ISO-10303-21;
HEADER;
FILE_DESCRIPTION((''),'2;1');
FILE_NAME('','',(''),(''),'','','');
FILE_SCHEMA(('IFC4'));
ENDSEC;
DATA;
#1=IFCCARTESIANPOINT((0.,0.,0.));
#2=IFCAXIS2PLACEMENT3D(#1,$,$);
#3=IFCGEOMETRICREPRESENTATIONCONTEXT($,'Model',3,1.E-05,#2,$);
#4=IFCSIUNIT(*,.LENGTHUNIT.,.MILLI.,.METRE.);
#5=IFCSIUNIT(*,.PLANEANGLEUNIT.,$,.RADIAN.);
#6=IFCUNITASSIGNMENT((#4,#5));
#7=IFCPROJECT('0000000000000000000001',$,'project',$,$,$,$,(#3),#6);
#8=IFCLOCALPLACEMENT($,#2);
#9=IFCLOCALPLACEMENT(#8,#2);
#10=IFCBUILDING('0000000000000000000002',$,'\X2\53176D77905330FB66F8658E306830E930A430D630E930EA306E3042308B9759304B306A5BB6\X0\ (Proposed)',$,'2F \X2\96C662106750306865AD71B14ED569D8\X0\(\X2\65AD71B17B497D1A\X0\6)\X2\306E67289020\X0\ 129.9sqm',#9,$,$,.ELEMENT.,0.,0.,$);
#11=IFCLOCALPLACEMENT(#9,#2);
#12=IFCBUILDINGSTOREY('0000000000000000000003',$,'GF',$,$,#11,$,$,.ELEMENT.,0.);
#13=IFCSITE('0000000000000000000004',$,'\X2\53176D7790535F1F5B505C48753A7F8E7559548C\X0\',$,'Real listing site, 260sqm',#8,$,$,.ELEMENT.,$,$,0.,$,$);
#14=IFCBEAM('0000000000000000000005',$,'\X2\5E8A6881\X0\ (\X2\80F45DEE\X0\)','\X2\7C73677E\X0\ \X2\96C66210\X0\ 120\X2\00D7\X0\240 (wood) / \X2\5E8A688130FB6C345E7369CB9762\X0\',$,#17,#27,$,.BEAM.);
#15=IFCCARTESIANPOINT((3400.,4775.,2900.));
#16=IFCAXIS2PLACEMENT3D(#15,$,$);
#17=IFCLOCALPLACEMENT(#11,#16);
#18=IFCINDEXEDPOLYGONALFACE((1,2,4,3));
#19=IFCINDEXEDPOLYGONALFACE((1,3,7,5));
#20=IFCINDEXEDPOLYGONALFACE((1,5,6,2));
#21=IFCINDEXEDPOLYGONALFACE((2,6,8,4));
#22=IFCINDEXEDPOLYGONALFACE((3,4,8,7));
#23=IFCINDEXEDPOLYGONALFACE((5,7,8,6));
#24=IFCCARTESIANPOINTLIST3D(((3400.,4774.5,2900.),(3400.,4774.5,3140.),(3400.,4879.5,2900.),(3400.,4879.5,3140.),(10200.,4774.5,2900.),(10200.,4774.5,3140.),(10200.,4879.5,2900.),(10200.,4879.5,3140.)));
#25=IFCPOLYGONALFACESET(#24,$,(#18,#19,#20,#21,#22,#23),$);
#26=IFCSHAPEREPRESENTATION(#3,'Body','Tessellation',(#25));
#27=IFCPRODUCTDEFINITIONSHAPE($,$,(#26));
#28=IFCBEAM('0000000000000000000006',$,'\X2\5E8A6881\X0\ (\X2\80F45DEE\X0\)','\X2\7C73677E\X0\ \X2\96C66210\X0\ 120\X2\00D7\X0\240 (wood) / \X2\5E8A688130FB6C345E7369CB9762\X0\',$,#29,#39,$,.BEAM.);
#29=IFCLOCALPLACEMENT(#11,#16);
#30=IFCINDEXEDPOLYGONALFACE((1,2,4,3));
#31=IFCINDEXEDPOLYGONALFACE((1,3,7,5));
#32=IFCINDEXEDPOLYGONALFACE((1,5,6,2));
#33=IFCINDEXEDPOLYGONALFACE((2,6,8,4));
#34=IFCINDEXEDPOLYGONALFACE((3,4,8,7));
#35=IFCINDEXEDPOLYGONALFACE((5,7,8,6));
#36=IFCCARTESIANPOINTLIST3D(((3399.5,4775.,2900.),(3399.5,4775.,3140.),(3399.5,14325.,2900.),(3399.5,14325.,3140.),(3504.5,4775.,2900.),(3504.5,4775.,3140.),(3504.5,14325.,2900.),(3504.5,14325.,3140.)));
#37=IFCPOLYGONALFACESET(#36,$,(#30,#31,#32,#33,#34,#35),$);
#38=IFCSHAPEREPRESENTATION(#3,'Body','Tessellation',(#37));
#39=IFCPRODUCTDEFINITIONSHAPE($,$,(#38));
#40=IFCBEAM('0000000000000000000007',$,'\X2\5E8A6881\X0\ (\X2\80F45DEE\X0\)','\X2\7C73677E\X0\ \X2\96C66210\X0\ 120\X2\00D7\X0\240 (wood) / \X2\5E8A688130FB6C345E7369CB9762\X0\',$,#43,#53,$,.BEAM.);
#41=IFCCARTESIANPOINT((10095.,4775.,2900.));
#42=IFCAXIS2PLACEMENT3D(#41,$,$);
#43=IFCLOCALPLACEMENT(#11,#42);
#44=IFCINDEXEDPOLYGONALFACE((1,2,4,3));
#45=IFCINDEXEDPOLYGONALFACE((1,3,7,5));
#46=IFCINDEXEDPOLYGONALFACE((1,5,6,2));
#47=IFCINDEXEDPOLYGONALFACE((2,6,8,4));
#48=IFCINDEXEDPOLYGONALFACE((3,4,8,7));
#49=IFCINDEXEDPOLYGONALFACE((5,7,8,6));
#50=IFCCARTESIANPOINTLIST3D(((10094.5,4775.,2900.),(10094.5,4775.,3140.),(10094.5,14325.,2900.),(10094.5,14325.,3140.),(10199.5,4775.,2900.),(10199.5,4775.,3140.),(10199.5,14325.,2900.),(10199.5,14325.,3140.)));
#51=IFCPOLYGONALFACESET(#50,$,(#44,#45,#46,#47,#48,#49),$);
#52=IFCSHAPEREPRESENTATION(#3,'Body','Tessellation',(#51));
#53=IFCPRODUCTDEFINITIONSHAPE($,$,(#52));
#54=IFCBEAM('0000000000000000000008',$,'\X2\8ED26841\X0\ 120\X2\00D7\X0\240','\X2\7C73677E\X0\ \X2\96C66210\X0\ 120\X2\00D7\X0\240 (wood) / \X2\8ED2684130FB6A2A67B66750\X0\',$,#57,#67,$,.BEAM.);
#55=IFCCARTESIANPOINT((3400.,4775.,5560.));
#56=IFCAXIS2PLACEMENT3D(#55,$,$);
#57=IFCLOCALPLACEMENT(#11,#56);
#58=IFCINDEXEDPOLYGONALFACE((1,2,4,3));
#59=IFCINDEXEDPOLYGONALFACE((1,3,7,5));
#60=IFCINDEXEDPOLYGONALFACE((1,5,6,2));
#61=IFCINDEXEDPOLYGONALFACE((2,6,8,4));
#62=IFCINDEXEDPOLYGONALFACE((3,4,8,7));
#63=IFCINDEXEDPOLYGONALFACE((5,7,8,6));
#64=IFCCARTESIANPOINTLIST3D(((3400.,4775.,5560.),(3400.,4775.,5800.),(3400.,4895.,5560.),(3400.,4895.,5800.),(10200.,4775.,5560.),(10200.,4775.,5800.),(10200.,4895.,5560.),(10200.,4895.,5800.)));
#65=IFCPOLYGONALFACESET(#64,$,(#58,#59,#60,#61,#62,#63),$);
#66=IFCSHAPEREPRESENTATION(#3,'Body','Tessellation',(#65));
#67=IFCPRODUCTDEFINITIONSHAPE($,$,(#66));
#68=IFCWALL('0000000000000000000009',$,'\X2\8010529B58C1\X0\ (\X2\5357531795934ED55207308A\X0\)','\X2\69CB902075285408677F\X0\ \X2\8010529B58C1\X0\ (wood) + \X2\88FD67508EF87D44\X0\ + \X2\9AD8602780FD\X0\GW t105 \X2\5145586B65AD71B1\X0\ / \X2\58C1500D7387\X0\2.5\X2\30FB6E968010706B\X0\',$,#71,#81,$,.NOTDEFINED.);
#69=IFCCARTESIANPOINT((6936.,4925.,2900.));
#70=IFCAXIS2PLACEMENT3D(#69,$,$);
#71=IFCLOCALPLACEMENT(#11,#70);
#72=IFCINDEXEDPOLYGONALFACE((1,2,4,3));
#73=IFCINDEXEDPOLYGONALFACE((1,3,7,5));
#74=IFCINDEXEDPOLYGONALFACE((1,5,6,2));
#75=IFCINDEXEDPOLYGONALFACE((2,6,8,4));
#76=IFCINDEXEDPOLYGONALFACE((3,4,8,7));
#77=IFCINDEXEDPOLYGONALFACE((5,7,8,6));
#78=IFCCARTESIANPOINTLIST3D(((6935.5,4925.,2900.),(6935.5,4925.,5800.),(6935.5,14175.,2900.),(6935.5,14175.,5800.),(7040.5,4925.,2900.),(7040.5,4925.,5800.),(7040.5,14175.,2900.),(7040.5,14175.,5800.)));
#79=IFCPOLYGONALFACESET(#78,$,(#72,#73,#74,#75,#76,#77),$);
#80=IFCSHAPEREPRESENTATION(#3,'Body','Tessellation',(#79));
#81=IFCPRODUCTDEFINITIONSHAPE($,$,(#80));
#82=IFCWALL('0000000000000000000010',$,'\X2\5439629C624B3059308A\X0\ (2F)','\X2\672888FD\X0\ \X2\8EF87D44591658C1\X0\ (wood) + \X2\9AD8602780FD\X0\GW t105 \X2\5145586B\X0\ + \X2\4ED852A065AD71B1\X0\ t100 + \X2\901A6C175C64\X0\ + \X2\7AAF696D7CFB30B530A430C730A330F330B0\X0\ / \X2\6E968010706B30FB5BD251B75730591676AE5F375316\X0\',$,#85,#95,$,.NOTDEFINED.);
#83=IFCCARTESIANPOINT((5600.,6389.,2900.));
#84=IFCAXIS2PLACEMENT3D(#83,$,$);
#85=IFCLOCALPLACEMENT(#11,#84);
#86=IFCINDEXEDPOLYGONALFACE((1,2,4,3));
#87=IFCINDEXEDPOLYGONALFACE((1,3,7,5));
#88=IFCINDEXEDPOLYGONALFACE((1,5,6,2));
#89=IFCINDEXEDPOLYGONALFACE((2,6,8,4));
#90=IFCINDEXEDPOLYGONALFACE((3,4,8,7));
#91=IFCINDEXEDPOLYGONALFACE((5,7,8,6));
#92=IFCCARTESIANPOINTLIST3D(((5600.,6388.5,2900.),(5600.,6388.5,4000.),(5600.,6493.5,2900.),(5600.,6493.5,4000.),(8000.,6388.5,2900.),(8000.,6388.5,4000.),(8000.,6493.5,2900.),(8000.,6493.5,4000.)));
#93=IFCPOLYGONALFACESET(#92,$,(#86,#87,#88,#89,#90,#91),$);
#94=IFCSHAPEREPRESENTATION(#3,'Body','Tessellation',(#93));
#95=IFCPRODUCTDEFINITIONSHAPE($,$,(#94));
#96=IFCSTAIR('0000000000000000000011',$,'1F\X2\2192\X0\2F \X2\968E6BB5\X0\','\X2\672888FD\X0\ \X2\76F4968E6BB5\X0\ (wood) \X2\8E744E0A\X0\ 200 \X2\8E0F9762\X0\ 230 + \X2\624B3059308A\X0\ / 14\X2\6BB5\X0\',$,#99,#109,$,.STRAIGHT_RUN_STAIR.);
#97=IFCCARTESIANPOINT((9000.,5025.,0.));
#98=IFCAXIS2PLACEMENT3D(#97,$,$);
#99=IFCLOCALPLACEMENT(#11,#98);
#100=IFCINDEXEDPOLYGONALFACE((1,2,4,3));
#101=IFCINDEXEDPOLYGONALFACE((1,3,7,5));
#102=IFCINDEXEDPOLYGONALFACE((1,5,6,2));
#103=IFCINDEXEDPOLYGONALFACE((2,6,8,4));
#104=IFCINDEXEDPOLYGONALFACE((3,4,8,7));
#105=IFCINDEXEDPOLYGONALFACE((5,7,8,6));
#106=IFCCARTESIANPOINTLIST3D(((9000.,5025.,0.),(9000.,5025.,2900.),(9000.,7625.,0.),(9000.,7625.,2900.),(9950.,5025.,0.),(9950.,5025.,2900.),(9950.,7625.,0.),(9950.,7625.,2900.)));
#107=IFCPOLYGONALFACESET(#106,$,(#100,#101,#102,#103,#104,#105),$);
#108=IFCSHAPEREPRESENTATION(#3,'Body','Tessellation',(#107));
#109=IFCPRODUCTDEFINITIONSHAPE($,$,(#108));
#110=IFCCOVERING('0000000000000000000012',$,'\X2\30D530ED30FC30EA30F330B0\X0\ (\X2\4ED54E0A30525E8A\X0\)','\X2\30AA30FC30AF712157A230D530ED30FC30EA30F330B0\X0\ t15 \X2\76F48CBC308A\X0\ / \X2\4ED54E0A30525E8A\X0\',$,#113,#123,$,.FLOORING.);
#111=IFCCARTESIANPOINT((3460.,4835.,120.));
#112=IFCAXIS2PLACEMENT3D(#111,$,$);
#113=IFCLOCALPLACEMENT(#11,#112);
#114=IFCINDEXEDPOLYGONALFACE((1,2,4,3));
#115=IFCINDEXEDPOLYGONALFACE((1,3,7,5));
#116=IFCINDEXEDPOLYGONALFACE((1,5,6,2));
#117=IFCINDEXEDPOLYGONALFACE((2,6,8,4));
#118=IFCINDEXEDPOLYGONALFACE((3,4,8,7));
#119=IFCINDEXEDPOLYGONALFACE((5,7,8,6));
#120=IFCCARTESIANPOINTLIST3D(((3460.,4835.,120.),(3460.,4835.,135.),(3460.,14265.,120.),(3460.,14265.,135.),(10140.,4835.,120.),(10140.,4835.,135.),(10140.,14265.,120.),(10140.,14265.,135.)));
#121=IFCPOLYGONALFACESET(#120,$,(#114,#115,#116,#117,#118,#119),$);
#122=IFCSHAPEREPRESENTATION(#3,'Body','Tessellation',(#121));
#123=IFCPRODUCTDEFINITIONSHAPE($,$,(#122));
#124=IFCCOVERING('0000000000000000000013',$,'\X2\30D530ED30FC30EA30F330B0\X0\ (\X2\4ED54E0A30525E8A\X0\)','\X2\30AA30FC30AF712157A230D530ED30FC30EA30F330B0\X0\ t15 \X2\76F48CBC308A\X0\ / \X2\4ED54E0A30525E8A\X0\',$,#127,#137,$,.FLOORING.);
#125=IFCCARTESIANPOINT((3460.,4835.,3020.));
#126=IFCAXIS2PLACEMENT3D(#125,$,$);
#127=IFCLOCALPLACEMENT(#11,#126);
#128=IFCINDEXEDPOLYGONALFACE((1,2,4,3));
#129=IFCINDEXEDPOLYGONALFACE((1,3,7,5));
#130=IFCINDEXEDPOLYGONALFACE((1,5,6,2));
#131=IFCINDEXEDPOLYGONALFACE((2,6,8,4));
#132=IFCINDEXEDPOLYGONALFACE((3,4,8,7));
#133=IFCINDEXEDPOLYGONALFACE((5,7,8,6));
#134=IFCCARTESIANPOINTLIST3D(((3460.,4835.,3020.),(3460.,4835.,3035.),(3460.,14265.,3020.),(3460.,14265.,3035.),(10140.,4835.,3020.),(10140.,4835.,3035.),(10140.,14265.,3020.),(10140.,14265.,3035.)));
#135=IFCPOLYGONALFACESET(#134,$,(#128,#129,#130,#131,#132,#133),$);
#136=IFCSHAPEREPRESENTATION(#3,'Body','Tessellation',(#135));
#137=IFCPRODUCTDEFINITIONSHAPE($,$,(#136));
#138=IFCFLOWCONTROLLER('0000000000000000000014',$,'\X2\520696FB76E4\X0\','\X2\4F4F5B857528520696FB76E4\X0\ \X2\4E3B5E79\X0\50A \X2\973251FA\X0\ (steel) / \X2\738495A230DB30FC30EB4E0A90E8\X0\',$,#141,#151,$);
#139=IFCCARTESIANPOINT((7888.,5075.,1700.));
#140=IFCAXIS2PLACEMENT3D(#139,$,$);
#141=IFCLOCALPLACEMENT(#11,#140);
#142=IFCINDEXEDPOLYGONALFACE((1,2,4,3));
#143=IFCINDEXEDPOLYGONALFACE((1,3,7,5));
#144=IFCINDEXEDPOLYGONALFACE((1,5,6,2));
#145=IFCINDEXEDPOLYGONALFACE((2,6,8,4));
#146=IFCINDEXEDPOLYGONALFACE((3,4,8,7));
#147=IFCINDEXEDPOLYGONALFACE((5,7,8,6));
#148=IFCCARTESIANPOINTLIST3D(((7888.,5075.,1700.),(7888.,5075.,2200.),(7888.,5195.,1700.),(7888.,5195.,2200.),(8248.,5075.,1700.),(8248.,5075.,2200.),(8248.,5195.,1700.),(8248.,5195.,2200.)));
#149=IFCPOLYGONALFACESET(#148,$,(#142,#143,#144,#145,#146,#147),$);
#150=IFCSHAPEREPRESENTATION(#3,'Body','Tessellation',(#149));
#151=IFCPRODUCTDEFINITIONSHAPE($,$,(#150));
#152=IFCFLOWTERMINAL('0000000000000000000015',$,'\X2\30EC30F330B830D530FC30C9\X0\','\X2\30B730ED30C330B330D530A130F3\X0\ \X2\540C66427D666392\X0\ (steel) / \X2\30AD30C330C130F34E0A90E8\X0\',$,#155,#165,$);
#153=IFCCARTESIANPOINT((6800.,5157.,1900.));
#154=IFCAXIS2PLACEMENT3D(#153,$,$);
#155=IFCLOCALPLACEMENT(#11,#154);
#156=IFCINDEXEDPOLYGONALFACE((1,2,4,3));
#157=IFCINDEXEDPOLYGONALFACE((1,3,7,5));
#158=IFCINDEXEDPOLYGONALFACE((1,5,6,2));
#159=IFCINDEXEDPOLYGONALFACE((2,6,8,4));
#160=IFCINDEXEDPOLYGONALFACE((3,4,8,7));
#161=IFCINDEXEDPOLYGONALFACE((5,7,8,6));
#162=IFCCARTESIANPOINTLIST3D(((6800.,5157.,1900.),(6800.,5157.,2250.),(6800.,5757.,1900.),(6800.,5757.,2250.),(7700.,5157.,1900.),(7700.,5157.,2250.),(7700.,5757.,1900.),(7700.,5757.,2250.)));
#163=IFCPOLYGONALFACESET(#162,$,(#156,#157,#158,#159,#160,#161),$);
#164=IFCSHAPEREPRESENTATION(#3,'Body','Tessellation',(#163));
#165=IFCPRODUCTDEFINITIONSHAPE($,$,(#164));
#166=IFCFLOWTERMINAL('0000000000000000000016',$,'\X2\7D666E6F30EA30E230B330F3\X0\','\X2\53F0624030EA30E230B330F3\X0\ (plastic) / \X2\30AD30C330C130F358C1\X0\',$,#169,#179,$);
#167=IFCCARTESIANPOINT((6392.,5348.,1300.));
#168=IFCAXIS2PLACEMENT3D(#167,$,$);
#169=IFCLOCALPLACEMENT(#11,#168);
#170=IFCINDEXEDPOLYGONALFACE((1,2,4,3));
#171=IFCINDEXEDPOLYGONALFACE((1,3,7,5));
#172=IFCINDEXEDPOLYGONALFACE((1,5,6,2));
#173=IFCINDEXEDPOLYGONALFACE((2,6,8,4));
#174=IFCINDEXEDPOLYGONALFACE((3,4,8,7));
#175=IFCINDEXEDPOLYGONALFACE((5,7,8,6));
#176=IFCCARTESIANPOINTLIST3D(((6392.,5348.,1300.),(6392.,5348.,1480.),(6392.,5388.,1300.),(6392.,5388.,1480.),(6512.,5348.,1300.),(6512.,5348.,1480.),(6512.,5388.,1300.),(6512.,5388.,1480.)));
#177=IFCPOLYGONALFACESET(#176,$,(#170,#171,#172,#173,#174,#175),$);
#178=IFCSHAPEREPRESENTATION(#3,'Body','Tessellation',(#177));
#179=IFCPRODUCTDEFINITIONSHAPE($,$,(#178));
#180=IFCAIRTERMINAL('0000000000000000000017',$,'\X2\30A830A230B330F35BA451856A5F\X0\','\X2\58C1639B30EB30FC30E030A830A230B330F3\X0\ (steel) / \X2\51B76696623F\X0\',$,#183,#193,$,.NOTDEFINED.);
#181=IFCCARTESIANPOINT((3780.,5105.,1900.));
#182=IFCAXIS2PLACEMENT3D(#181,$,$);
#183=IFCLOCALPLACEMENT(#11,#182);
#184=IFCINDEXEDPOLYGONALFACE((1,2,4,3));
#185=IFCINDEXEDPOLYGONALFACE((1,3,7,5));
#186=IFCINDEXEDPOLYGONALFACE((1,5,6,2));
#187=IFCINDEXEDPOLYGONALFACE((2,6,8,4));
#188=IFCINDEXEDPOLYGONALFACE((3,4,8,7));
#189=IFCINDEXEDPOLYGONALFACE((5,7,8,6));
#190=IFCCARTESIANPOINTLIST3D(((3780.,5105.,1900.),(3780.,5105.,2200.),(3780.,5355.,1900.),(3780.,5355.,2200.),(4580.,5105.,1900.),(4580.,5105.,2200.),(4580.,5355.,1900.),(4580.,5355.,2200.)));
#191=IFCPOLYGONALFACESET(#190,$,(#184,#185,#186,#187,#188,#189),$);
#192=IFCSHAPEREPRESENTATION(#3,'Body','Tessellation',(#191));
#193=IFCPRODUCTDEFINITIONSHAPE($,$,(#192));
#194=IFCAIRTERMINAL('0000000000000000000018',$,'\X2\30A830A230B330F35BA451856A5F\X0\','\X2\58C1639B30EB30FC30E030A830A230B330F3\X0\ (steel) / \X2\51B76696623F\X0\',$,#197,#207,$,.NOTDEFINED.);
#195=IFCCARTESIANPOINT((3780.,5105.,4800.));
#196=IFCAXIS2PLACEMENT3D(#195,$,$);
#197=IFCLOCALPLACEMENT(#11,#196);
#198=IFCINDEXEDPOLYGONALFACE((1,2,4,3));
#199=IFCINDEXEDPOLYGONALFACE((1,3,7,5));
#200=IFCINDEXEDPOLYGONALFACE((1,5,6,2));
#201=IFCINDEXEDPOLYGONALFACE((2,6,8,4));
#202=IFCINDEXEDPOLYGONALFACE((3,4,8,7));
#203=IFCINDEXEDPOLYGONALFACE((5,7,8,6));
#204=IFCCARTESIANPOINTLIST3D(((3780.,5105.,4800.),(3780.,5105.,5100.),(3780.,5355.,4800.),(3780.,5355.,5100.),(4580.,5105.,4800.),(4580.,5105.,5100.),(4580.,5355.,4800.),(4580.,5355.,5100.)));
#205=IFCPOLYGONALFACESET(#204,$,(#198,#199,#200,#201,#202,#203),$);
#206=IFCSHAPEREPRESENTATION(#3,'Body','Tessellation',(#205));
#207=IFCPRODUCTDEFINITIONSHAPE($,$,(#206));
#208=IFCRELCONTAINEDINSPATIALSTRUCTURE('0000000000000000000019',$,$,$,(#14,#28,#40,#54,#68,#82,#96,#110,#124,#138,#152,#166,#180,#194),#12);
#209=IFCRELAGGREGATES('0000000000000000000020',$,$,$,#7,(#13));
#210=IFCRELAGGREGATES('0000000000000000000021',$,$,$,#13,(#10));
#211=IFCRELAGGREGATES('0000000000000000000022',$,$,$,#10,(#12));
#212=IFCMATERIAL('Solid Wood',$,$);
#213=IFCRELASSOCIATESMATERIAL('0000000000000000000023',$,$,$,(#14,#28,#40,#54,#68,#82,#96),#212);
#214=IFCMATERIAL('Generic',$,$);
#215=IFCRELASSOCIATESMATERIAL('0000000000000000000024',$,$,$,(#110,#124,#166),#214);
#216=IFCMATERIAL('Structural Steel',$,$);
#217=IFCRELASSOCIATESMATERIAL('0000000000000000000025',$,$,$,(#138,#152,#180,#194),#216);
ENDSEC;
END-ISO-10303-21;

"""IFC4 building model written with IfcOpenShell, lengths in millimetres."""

from ifc_helpers import new_model, si_unit, frame, frame_2d, origin, place, context, project, spatial, rectangle, extrude, material, element, save


model = new_model("IFC4")

# Units and contexts
model_context = context("Model", 3, precision=1e-05, world=origin())
ifc_project = project(units=[si_unit("LENGTHUNIT", "METRE", prefix="MILLI"), si_unit("PLANEANGLEUNIT", "RADIAN")], contexts=[model_context])

# Site, building, storey
site_placement = place(None, origin())
site = spatial("IfcSite", under=ifc_project, at=site_placement, Name="北海道弟子屈町美留和", ObjectType="Real listing site, 260sqm", CompositionType="ELEMENT", RefElevation=0.0)
building_placement = place(site_placement, origin())
building = spatial("IfcBuilding", under=site, at=building_placement, Name="北海道・書斎とライブラリのある静かな家 (Proposed)", ObjectType="2F 集成材と断熱仕様(断熱等級6)の木造 129.9sqm", CompositionType="ELEMENT", ElevationOfRefHeight=0.0, ElevationOfTerrain=0.0)
storey_placement = place(building_placement, origin())
storey = spatial("IfcBuildingStorey", under=building, at=storey_placement, Name="GF", CompositionType="ELEMENT", Elevation=0.0)

# Shared definitions
ifc_material_1 = material(Name="Solid Wood")

# Beams
beam_1_placement = place(storey_placement, frame((3400.0, 4775.0, 2900.0)))
element("IfcBeam", 1, at=beam_1_placement, inside=storey, material=ifc_material_1, Name="床梁 (胴差)", Description="米松 集成 120×240 (wood) / 床梁・水平構面", PredefinedType="BEAM", context=model_context, shape_type="SweptSolid", body=[
    extrude(rectangle(XDim=6800.0, YDim=105.0, at=frame_2d((3400.0, 52.0))), frame((3400.0, 4775.0, 2900.0)), (0.0, 0.0, 1.0), 240.0),
])
beam_2_placement = place(storey_placement, frame((3400.0, 4775.0, 2900.0)))
element("IfcBeam", 2, at=beam_2_placement, inside=storey, material=ifc_material_1, Name="床梁 (胴差)", Description="米松 集成 120×240 (wood) / 床梁・水平構面", PredefinedType="BEAM", context=model_context, shape_type="SweptSolid", body=[
    extrude(rectangle(XDim=105.0, YDim=9550.0, at=frame_2d((52.0, 4775.0))), frame((3400.0, 4775.0, 2900.0)), (0.0, 0.0, 1.0), 240.0),
])
beam_3_placement = place(storey_placement, frame((10095.0, 4775.0, 2900.0)))
element("IfcBeam", 3, at=beam_3_placement, inside=storey, material=ifc_material_1, Name="床梁 (胴差)", Description="米松 集成 120×240 (wood) / 床梁・水平構面", PredefinedType="BEAM", context=model_context, shape_type="SweptSolid", body=[
    extrude(rectangle(XDim=105.0, YDim=9550.0, at=frame_2d((52.0, 4775.0))), frame((10095.0, 4775.0, 2900.0)), (0.0, 0.0, 1.0), 240.0),
])
beam_4_placement = place(storey_placement, frame((3400.0, 4775.0, 5560.0)))
element("IfcBeam", 4, at=beam_4_placement, inside=storey, material=ifc_material_1, Name="軒桁 120×240", Description="米松 集成 120×240 (wood) / 軒桁・横架材", PredefinedType="BEAM", context=model_context, shape_type="SweptSolid", body=[
    extrude(rectangle(XDim=6800.0, YDim=120.0, at=frame_2d((3400.0, 60.0))), frame((3400.0, 4775.0, 5560.0)), (0.0, 0.0, 1.0), 240.0),
])

# Walls
wall_1_placement = place(storey_placement, frame((6936.0, 4925.0, 2900.0)))
element("IfcWall", 5, at=wall_1_placement, inside=storey, material=ifc_material_1, Name="耐力壁 (南北間仕切り)", Description="構造用合板 耐力壁 (wood) + 製材軸組 + 高性能GW t105 充填断熱 / 壁倍率2.5・準耐火", PredefinedType="NOTDEFINED", context=model_context, shape_type="SweptSolid", body=[
    extrude(rectangle(XDim=105.0, YDim=9250.0, at=frame_2d((52.0, 4625.0))), frame((6936.0, 4925.0, 2900.0)), (0.0, 0.0, 1.0), 2900.0),
])
wall_2_placement = place(storey_placement, frame((5600.0, 6389.0, 2900.0)))
element("IfcWall", 6, at=wall_2_placement, inside=storey, material=ifc_material_1, Name="吹抜手すり (2F)", Description="木製 軸組外壁 (wood) + 高性能GW t105 充填 + 付加断熱 t100 + 通気層 + 窯業系サイディング / 準耐火・寒冷地外皮強化", PredefinedType="NOTDEFINED", context=model_context, shape_type="SweptSolid", body=[
    extrude(rectangle(XDim=2400.0, YDim=105.0, at=frame_2d((1200.0, 52.0))), frame((5600.0, 6389.0, 2900.0)), (0.0, 0.0, 1.0), 1100.0),
])

# Stair
stair_placement = place(storey_placement, frame((9000.0, 5025.0, 0.0)))
element("IfcStair", 7, at=stair_placement, inside=storey, material=ifc_material_1, Name="1F→2F 階段", Description="木製 直階段 (wood) 蹴上 200 踏面 230 + 手すり / 14段", PredefinedType="STRAIGHT_RUN_STAIR", context=model_context, shape_type="SweptSolid", body=[
    extrude(rectangle(XDim=950.0, YDim=2600.0, at=frame_2d((475.0, 1300.0))), frame((9000.0, 5025.0, 0.0)), (0.0, 0.0, 1.0), 2900.0),
])

# Coverings
ifc_material_2 = material(Name="Generic")
covering_1_placement = place(storey_placement, frame((3460.0, 4835.0, 120.0)))
element("IfcCovering", 8, at=covering_1_placement, inside=storey, material=ifc_material_2, Name="フローリング (仕上げ床)", Description="オーク無垢フローリング t15 直貼り / 仕上げ床", PredefinedType="FLOORING", context=model_context, shape_type="SweptSolid", body=[
    extrude(rectangle(XDim=6680.0, YDim=9430.0, at=frame_2d((3340.0, 4715.0))), frame((3460.0, 4835.0, 120.0)), (0.0, 0.0, 1.0), 15.0),
])
covering_2_placement = place(storey_placement, frame((3460.0, 4835.0, 3020.0)))
element("IfcCovering", 9, at=covering_2_placement, inside=storey, material=ifc_material_2, Name="フローリング (仕上げ床)", Description="オーク無垢フローリング t15 直貼り / 仕上げ床", PredefinedType="FLOORING", context=model_context, shape_type="SweptSolid", body=[
    extrude(rectangle(XDim=6680.0, YDim=9430.0, at=frame_2d((3340.0, 4715.0))), frame((3460.0, 4835.0, 3020.0)), (0.0, 0.0, 1.0), 15.0),
])

# Flow controller
ifc_material_3 = material(Name="Structural Steel")
flow_controller_placement = place(storey_placement, frame((7888.0, 5075.0, 1700.0)))
element("IfcFlowController", 10, at=flow_controller_placement, inside=storey, material=ifc_material_3, Name="分電盤", Description="住宅用分電盤 主幹50A 露出 (steel) / 玄関ホール上部", context=model_context, shape_type="SweptSolid", body=[
    extrude(rectangle(XDim=360.0, YDim=120.0, at=frame_2d((180.0, 60.0))), frame((7888.0, 5075.0, 1700.0)), (0.0, 0.0, 1.0), 500.0),
])

# Flow terminals
flow_terminal_1_placement = place(storey_placement, frame((6800.0, 5157.0, 1900.0)))
element("IfcFlowTerminal", 11, at=flow_terminal_1_placement, inside=storey, material=ifc_material_3, Name="レンジフード", Description="シロッコファン 同時給排 (steel) / キッチン上部", context=model_context, shape_type="SweptSolid", body=[
    extrude(rectangle(XDim=900.0, YDim=600.0, at=frame_2d((450.0, 300.0))), frame((6800.0, 5157.0, 1900.0)), (0.0, 0.0, 1.0), 350.0),
])
flow_terminal_2_placement = place(storey_placement, frame((6392.0, 5348.0, 1300.0)))
element("IfcFlowTerminal", 12, at=flow_terminal_2_placement, inside=storey, material=ifc_material_2, Name="給湯リモコン", Description="台所リモコン (plastic) / キッチン壁", context=model_context, shape_type="SweptSolid", body=[
    extrude(rectangle(XDim=120.0, YDim=40.0, at=frame_2d((60.0, 20.0))), frame((6392.0, 5348.0, 1300.0)), (0.0, 0.0, 1.0), 180.0),
])

# Air terminals
air_terminal_1_placement = place(storey_placement, frame((3780.0, 5105.0, 1900.0)))
element("IfcAirTerminal", 13, at=air_terminal_1_placement, inside=storey, material=ifc_material_3, Name="エアコン室内機", Description="壁掛ルームエアコン (steel) / 冷暖房", PredefinedType="NOTDEFINED", context=model_context, shape_type="SweptSolid", body=[
    extrude(rectangle(XDim=800.0, YDim=250.0, at=frame_2d((400.0, 125.0))), frame((3780.0, 5105.0, 1900.0)), (0.0, 0.0, 1.0), 300.0),
])
air_terminal_2_placement = place(storey_placement, frame((3780.0, 5105.0, 4800.0)))
element("IfcAirTerminal", 14, at=air_terminal_2_placement, inside=storey, material=ifc_material_3, Name="エアコン室内機", Description="壁掛ルームエアコン (steel) / 冷暖房", PredefinedType="NOTDEFINED", context=model_context, shape_type="SweptSolid", body=[
    extrude(rectangle(XDim=800.0, YDim=250.0, at=frame_2d((400.0, 125.0))), frame((3780.0, 5105.0, 4800.0)), (0.0, 0.0, 1.0), 300.0),
])

save(model, "model.ifc")
